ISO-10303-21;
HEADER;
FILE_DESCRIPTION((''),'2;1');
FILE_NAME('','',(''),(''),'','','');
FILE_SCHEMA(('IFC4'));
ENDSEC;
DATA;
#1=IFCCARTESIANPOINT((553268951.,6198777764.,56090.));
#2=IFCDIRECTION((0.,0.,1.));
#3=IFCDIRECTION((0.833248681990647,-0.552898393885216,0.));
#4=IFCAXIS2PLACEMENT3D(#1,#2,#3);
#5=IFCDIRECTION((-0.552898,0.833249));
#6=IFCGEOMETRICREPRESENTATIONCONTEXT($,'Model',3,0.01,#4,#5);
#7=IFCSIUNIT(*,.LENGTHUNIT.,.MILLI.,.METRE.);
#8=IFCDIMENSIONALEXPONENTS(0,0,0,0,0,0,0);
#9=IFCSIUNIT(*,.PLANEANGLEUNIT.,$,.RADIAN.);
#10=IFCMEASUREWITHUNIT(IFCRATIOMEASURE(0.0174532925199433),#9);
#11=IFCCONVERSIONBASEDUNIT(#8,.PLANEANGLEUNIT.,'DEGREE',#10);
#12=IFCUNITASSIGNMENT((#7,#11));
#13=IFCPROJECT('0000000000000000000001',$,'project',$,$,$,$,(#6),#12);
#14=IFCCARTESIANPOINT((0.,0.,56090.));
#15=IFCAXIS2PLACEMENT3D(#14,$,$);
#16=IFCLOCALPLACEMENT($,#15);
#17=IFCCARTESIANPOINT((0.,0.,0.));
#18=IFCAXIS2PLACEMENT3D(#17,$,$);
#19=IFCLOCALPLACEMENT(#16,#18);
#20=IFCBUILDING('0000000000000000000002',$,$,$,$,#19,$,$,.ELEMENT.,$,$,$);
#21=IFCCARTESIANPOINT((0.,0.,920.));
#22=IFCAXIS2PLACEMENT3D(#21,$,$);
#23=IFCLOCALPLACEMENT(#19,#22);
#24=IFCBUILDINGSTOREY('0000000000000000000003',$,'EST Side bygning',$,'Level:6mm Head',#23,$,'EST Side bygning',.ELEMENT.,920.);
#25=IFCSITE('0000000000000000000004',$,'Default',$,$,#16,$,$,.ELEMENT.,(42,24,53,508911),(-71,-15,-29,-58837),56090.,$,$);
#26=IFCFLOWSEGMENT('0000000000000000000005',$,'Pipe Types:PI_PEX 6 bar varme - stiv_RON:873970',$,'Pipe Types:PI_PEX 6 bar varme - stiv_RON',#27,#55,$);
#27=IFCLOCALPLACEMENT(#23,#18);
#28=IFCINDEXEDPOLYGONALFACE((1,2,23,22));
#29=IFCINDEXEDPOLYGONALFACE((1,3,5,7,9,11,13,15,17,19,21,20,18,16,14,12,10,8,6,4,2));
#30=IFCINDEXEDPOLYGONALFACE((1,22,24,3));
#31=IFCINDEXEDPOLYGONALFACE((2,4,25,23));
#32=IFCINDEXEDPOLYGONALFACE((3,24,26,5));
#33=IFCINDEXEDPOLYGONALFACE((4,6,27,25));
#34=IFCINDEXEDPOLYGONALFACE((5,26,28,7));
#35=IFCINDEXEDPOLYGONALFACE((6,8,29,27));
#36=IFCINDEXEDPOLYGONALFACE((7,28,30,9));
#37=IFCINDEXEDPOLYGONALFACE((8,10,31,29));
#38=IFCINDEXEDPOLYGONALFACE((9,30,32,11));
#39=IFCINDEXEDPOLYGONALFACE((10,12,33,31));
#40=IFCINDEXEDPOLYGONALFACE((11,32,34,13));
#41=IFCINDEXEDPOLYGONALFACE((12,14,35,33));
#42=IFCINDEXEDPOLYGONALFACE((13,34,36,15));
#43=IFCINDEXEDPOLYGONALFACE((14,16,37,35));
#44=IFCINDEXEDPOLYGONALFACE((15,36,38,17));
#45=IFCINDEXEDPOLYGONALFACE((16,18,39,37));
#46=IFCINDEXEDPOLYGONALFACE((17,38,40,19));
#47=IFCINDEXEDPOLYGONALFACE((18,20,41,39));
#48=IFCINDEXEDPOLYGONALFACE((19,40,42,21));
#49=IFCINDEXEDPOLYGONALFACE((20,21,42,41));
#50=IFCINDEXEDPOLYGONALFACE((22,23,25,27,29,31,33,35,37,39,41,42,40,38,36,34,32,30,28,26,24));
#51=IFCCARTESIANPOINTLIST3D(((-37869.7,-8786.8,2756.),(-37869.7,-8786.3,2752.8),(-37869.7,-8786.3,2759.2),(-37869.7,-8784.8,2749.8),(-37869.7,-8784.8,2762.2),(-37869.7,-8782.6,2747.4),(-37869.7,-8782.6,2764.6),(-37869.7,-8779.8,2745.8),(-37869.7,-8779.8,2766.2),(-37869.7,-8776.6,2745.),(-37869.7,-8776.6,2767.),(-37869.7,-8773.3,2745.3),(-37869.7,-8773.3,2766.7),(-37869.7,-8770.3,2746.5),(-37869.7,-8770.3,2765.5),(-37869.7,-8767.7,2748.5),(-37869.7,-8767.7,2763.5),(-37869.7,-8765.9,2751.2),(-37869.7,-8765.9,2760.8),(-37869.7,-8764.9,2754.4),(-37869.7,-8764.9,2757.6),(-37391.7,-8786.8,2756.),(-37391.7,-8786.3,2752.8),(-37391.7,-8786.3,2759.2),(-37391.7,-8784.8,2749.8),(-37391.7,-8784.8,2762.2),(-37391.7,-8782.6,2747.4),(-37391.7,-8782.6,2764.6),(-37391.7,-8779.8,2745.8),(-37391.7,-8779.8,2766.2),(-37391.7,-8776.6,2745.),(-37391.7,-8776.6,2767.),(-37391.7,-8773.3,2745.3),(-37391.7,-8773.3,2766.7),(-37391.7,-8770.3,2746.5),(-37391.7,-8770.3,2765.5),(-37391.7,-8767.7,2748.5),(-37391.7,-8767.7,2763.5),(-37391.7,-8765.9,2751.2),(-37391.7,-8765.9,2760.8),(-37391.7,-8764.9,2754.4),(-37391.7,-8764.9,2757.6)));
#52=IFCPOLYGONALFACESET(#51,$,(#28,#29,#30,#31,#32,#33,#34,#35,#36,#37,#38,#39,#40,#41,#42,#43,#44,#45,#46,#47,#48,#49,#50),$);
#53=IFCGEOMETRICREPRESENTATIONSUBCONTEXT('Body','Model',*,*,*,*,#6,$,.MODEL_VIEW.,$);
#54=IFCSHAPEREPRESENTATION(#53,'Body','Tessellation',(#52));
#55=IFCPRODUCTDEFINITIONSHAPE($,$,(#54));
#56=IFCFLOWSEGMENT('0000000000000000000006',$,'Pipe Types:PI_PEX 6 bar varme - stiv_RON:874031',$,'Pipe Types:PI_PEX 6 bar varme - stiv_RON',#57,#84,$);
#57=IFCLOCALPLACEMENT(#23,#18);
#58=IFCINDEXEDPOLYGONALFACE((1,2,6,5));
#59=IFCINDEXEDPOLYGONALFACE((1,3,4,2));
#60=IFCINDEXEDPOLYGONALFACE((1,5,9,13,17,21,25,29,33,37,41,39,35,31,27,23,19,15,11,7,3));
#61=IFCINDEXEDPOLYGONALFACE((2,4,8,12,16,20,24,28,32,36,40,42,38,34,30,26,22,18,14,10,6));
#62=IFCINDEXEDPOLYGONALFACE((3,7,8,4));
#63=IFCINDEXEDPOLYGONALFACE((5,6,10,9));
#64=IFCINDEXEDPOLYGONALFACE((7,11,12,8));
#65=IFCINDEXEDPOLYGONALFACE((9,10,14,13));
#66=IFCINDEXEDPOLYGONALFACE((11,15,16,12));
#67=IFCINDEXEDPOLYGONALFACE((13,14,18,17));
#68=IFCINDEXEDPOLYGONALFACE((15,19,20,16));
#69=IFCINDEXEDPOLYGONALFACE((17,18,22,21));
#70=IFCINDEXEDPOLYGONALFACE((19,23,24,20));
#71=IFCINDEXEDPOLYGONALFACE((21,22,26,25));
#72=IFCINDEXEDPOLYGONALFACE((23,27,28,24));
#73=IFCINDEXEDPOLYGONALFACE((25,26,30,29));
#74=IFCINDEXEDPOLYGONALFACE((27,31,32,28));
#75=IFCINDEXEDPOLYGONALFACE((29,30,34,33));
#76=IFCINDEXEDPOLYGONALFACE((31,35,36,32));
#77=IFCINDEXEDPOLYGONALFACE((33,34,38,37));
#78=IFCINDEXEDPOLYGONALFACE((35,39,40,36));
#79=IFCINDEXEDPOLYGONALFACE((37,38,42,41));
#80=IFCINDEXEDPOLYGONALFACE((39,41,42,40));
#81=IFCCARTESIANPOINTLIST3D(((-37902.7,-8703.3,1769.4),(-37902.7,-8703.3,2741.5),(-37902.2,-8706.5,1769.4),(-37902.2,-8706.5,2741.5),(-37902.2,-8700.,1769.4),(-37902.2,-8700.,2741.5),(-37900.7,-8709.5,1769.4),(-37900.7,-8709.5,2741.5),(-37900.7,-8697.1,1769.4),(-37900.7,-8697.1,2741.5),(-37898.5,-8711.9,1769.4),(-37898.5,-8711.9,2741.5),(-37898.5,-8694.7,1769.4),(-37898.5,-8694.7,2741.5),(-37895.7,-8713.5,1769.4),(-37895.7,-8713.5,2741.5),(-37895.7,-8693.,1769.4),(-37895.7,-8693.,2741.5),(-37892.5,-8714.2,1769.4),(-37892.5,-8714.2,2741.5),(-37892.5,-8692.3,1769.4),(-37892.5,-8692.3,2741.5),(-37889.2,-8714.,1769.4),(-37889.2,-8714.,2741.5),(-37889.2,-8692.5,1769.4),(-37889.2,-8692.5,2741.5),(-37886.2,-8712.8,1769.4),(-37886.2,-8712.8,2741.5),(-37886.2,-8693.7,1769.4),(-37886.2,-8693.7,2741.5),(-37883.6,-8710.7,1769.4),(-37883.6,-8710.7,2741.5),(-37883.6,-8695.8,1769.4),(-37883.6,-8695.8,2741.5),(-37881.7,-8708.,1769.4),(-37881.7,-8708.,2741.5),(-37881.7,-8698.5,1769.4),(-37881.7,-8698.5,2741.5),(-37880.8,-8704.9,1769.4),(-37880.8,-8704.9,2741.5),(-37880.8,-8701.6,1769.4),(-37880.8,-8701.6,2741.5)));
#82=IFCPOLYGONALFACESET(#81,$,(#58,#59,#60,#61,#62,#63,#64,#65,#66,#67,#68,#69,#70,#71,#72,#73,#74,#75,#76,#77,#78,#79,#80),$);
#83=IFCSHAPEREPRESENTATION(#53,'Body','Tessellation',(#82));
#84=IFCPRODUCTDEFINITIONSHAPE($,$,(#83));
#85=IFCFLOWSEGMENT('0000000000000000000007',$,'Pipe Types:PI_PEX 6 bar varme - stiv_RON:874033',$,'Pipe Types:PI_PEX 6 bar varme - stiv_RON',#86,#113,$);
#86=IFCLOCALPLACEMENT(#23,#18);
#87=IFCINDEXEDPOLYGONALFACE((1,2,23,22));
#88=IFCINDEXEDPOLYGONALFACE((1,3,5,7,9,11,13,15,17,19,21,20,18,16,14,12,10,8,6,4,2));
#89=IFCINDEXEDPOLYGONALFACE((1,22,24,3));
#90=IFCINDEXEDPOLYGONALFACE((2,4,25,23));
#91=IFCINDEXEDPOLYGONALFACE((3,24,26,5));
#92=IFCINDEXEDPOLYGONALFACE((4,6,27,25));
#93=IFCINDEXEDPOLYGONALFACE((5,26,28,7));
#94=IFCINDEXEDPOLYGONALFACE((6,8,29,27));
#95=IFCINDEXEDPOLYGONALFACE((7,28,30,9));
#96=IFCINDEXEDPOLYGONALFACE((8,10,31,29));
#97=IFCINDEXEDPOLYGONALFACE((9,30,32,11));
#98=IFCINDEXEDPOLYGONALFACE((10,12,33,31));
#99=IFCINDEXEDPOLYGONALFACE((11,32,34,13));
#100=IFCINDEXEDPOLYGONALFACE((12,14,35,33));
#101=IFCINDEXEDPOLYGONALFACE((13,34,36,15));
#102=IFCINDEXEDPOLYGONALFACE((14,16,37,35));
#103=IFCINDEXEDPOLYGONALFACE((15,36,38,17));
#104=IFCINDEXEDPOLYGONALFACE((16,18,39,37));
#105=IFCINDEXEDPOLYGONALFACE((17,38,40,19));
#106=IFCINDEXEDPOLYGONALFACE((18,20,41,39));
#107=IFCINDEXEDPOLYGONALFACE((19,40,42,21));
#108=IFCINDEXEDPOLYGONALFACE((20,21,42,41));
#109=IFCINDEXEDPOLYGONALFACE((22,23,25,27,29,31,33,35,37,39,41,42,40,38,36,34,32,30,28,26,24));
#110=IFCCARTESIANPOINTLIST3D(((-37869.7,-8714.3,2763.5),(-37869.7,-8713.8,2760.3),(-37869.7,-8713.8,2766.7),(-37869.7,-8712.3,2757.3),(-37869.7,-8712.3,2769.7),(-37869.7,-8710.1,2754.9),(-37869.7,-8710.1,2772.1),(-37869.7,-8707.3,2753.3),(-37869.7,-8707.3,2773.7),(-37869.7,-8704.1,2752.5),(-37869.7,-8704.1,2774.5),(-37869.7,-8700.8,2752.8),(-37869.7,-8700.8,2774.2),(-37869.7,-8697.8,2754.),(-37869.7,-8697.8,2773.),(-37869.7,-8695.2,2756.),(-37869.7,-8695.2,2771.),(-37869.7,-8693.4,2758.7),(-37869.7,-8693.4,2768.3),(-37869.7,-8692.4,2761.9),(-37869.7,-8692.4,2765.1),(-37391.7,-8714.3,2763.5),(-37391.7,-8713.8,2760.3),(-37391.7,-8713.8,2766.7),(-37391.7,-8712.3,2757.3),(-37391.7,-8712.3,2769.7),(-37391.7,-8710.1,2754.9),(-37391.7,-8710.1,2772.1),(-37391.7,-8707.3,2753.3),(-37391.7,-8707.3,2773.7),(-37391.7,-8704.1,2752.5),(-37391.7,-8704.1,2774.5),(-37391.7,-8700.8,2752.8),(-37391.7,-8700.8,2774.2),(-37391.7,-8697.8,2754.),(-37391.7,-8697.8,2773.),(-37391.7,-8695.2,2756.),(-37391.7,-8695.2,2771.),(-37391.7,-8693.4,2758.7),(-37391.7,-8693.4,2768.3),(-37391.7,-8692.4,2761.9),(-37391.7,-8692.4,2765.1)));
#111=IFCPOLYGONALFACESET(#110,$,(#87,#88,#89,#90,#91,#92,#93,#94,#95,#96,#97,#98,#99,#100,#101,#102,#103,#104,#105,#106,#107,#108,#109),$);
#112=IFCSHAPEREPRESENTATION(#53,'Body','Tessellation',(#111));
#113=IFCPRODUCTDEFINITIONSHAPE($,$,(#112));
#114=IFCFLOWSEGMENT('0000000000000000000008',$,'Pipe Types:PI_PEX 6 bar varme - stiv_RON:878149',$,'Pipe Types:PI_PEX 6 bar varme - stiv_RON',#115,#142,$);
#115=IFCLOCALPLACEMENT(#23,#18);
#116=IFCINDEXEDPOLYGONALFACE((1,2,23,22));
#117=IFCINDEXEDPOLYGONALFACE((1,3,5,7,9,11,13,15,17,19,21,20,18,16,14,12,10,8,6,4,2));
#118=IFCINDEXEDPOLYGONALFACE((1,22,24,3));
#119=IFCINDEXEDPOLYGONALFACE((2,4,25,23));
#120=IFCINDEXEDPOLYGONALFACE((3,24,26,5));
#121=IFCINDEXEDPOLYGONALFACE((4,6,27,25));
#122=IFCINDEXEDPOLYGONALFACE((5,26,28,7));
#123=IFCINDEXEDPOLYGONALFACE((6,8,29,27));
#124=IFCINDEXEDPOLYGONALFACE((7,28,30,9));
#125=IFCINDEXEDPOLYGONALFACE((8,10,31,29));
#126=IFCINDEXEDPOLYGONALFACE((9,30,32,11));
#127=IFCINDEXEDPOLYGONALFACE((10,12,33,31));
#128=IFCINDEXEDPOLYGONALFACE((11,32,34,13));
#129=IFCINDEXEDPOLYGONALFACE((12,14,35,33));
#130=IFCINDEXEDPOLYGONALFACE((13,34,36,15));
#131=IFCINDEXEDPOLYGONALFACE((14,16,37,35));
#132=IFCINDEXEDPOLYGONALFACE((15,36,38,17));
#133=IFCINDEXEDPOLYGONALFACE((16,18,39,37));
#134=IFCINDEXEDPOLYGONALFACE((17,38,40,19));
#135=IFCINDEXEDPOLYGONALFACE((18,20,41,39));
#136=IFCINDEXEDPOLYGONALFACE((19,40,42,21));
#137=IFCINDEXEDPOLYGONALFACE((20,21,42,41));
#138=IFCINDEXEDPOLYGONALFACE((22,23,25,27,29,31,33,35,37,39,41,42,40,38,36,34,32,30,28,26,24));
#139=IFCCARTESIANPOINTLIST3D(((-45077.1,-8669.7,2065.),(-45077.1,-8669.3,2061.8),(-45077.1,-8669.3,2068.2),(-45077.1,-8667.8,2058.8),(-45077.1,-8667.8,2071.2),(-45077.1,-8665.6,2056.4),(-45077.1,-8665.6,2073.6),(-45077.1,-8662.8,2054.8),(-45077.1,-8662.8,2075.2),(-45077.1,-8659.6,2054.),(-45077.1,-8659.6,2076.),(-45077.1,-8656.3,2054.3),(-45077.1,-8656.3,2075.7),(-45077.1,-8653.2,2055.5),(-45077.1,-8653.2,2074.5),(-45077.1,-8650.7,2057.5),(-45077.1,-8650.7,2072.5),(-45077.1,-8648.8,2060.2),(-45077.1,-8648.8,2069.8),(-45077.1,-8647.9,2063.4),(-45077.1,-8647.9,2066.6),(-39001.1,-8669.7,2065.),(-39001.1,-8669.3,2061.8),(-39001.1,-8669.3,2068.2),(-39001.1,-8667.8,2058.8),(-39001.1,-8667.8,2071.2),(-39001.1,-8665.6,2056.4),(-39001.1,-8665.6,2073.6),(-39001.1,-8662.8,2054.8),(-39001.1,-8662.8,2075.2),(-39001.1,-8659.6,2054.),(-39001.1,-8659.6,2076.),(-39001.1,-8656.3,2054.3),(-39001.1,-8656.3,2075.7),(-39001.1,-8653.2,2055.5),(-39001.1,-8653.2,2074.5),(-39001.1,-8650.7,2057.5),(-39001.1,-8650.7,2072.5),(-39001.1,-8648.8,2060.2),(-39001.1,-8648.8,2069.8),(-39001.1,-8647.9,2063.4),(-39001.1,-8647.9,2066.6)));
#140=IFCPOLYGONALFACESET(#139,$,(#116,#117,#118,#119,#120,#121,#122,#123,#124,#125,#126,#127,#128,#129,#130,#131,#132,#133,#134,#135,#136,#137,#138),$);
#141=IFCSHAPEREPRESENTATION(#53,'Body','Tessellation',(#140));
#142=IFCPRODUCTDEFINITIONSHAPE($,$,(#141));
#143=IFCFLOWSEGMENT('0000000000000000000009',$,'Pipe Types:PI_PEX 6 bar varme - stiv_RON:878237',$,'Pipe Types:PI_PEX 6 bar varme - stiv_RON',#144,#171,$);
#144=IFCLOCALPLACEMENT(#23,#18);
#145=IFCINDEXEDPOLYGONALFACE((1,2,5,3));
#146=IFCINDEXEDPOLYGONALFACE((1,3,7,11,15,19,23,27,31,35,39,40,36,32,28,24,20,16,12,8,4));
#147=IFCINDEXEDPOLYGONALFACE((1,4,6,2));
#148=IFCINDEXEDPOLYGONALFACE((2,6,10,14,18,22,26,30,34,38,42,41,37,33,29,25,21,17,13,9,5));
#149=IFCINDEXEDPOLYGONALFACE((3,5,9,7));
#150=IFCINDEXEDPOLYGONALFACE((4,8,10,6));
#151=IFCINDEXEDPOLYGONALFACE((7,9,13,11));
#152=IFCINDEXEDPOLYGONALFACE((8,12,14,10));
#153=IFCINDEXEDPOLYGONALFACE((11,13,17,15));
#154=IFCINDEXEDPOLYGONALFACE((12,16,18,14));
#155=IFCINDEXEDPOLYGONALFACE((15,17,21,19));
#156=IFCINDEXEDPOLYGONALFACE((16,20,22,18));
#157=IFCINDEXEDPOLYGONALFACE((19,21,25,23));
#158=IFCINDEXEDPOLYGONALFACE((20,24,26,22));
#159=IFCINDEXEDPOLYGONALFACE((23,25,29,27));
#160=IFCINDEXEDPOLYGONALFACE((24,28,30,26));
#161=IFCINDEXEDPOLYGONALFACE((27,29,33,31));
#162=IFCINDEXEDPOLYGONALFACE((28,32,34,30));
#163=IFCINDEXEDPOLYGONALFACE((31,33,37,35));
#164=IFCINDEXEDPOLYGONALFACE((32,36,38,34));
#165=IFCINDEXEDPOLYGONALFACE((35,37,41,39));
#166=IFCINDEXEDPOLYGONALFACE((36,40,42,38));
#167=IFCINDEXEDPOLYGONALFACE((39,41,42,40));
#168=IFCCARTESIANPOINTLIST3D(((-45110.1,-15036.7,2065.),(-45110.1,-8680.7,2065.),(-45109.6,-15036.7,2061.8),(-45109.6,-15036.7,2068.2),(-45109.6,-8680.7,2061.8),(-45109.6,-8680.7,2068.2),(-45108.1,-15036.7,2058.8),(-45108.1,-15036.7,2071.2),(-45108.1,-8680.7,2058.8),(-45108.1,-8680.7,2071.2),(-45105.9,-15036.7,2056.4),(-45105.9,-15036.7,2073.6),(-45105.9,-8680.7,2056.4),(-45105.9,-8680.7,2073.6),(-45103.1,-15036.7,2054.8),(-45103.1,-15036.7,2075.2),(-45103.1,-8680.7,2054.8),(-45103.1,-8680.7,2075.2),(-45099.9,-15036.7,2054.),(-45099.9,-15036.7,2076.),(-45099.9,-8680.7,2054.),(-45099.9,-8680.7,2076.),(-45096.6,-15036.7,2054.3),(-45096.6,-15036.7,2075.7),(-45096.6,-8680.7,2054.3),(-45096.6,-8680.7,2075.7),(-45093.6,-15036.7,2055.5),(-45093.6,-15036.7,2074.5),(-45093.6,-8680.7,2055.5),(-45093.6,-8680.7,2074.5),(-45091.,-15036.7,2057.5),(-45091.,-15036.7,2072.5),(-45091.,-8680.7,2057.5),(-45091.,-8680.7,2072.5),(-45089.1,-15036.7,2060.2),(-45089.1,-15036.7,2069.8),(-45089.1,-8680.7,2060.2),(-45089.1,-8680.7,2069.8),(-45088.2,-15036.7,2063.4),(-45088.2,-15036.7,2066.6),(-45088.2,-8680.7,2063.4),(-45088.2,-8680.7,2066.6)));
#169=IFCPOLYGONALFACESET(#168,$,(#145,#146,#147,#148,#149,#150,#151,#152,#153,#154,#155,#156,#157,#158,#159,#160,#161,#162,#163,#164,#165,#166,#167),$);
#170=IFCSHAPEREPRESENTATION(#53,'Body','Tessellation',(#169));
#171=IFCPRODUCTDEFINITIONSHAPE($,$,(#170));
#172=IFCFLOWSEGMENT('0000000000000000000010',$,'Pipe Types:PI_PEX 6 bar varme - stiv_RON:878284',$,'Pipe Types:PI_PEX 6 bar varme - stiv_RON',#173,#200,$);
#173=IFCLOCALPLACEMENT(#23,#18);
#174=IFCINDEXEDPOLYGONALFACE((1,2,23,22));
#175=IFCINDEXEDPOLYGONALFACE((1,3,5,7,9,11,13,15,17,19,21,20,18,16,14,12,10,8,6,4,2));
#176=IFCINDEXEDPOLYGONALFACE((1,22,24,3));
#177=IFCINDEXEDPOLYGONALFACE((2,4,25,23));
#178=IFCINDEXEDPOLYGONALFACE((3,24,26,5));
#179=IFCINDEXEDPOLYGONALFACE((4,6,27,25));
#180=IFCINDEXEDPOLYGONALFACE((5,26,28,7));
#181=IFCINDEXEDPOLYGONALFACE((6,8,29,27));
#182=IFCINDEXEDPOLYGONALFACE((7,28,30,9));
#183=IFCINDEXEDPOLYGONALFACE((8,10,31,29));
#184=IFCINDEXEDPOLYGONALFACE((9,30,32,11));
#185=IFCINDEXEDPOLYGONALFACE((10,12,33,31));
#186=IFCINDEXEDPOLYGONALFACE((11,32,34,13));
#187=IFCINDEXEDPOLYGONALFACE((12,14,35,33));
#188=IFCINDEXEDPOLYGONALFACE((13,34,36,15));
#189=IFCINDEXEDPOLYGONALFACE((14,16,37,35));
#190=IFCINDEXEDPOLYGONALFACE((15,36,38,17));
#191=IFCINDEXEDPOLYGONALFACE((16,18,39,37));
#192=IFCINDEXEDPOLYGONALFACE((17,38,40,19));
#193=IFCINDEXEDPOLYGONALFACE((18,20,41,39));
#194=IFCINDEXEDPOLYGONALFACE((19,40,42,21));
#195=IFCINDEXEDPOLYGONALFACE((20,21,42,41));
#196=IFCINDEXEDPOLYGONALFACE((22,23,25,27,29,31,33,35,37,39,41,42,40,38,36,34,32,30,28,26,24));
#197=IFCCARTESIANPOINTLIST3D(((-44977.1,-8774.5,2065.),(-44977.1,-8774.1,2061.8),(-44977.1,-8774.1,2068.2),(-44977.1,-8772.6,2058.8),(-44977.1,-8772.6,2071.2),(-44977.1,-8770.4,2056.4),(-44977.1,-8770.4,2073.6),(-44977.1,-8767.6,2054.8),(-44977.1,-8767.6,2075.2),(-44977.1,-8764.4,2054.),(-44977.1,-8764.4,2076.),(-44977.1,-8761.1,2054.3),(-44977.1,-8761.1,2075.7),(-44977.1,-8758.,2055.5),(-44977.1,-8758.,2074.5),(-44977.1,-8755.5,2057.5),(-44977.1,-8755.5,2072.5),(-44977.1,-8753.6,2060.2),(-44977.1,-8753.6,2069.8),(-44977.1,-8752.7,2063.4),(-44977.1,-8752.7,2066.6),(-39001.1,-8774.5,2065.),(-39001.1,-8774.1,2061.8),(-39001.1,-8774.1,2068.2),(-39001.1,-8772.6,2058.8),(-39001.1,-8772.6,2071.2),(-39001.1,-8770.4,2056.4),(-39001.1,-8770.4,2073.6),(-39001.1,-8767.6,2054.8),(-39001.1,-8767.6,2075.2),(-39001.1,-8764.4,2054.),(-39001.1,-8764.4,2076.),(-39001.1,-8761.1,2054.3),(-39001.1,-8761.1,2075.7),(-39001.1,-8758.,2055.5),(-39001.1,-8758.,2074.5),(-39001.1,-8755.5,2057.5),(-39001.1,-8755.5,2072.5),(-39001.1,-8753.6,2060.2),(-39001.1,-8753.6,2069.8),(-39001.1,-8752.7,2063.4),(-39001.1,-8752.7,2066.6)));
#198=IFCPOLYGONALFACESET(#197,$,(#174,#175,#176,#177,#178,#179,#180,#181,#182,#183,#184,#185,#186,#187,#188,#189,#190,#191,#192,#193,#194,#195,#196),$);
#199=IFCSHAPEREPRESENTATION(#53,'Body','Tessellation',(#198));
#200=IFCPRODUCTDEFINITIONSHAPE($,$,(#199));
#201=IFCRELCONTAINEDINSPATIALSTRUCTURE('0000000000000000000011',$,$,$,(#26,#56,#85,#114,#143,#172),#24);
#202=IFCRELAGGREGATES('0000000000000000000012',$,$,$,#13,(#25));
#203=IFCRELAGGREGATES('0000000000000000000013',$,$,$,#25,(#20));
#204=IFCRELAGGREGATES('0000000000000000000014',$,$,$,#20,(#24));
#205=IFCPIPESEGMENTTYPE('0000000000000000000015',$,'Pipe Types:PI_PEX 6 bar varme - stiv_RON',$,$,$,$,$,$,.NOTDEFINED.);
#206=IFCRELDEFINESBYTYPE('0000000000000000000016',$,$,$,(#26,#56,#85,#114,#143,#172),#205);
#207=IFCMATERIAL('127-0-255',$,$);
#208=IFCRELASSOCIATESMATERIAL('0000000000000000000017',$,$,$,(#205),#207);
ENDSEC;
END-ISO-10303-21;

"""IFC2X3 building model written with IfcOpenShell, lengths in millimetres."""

from ifc_helpers import new_model, entity, si_unit, converted_unit, direction, frame, origin, origin_2d_with_axis, place, context, subcontext, project, spatial, circle, extrude, material, type_object, element, save


model = new_model("IFC2X3")

# Units and contexts
model_context = context("Model", 3, precision=0.01, world=frame((553268951.0, 6198777764.0, 56090.0), z_axis=(0.0, 0.0, 1.0), x_axis=(0.833248681990647, -0.552898393885216, 0.0)), true_north=direction((-0.552898, 0.833249)))
body_context = subcontext(model_context, "Body", "Model", "MODEL_VIEW")
ifc_project = project(units=[si_unit("LENGTHUNIT", "METRE", prefix="MILLI"), converted_unit("PLANEANGLEUNIT", "DEGREE", entity("IfcRatioMeasure", 0.0174532925199433), si_unit("PLANEANGLEUNIT", "RADIAN"), dimensions=[0, 0, 0, 0, 0, 0, 0])], contexts=[model_context])

# Site, building, storey
site_placement = place(None, frame((0.0, 0.0, 56090.0)))
site = spatial("IfcSite", under=ifc_project, at=site_placement, Name="Default", CompositionType="ELEMENT", RefLatitude=(42, 24, 53, 508911), RefLongitude=(-71, -15, -29, -58837), RefElevation=56090.0)
building_placement = place(site_placement, origin())
building = spatial("IfcBuilding", under=site, at=building_placement, CompositionType="ELEMENT")
storey_placement = place(building_placement, frame((0.0, 0.0, 920.0)))
storey = spatial("IfcBuildingStorey", under=building, at=storey_placement, Name="EST Side bygning", ObjectType="Level:6mm Head", LongName="EST Side bygning", CompositionType="ELEMENT", Elevation=920.0)

# Flow segments
ifc_material_1 = material(Name="127-0-255")
pipe_segment_type_1 = type_object("IfcPipeSegmentType", Name="Pipe Types:PI_PEX 6 bar varme - stiv_RON", PredefinedType="NOTDEFINED", material=ifc_material_1)
flow_segment_1_placement = place(storey_placement, origin())
element("IfcFlowSegment", 1, at=flow_segment_1_placement, inside=storey, type_object=pipe_segment_type_1, Name="Pipe Types:PI_PEX 6 bar varme - stiv_RON:873970", ObjectType="Pipe Types:PI_PEX 6 bar varme - stiv_RON", context=body_context, shape_type="SweptSolid", body=[
    extrude(circle(Radius=11.0, at=origin_2d_with_axis()), frame((-37869.7, -8775.8, 2756.0), z_axis=(1.0, 0.0, 0.0), x_axis=(0.0, -1.0, 0.0)), (0.0, 0.0, 1.0), 478.0),
])
flow_segment_2_placement = place(storey_placement, origin())
element("IfcFlowSegment", 2, at=flow_segment_2_placement, inside=storey, type_object=pipe_segment_type_1, Name="Pipe Types:PI_PEX 6 bar varme - stiv_RON:874031", ObjectType="Pipe Types:PI_PEX 6 bar varme - stiv_RON", context=body_context, shape_type="SweptSolid", body=[
    extrude(circle(Radius=11.0, at=origin_2d_with_axis()), frame((-37891.7, -8703.3, 1769.4), z_axis=(0.0, 0.0, 1.0), x_axis=(-1.0, 0.0, 0.0)), (0.0, 0.0, 1.0), 972.1),
])
flow_segment_3_placement = place(storey_placement, origin())
element("IfcFlowSegment", 3, at=flow_segment_3_placement, inside=storey, type_object=pipe_segment_type_1, Name="Pipe Types:PI_PEX 6 bar varme - stiv_RON:874033", ObjectType="Pipe Types:PI_PEX 6 bar varme - stiv_RON", context=body_context, shape_type="SweptSolid", body=[
    extrude(circle(Radius=11.0, at=origin_2d_with_axis()), frame((-37869.7, -8703.3, 2763.5), z_axis=(1.0, 0.0, 0.0), x_axis=(0.0, -1.0, 0.0)), (0.0, 0.0, 1.0), 478.0),
])
flow_segment_4_placement = place(storey_placement, origin())
element("IfcFlowSegment", 4, at=flow_segment_4_placement, inside=storey, type_object=pipe_segment_type_1, Name="Pipe Types:PI_PEX 6 bar varme - stiv_RON:878149", ObjectType="Pipe Types:PI_PEX 6 bar varme - stiv_RON", context=body_context, shape_type="SweptSolid", body=[
    extrude(circle(Radius=11.0, at=origin_2d_with_axis()), frame((-45077.1, -8658.7, 2065.0), z_axis=(1.0, 0.0, 0.0), x_axis=(0.0, -1.0, 0.0)), (0.0, 0.0, 1.0), 6076.0),
])
flow_segment_5_placement = place(storey_placement, origin())
element("IfcFlowSegment", 5, at=flow_segment_5_placement, inside=storey, type_object=pipe_segment_type_1, Name="Pipe Types:PI_PEX 6 bar varme - stiv_RON:878237", ObjectType="Pipe Types:PI_PEX 6 bar varme - stiv_RON", context=body_context, shape_type="SweptSolid", body=[
    extrude(circle(Radius=11.0, at=origin_2d_with_axis()), frame((-45099.1, -15036.7, 2065.0), z_axis=(0.0, 1.0, 0.0), x_axis=(-1.0, 0.0, 0.0)), (0.0, 0.0, 1.0), 6356.0),
])
flow_segment_6_placement = place(storey_placement, origin())
element("IfcFlowSegment", 6, at=flow_segment_6_placement, inside=storey, type_object=pipe_segment_type_1, Name="Pipe Types:PI_PEX 6 bar varme - stiv_RON:878284", ObjectType="Pipe Types:PI_PEX 6 bar varme - stiv_RON", context=body_context, shape_type="SweptSolid", body=[
    extrude(circle(Radius=11.0, at=origin_2d_with_axis()), frame((-44977.1, -8763.5, 2065.0), z_axis=(1.0, 0.0, 0.0), x_axis=(0.0, -1.0, 0.0)), (0.0, 0.0, 1.0), 5976.0),
])

save(model, "model.ifc")
